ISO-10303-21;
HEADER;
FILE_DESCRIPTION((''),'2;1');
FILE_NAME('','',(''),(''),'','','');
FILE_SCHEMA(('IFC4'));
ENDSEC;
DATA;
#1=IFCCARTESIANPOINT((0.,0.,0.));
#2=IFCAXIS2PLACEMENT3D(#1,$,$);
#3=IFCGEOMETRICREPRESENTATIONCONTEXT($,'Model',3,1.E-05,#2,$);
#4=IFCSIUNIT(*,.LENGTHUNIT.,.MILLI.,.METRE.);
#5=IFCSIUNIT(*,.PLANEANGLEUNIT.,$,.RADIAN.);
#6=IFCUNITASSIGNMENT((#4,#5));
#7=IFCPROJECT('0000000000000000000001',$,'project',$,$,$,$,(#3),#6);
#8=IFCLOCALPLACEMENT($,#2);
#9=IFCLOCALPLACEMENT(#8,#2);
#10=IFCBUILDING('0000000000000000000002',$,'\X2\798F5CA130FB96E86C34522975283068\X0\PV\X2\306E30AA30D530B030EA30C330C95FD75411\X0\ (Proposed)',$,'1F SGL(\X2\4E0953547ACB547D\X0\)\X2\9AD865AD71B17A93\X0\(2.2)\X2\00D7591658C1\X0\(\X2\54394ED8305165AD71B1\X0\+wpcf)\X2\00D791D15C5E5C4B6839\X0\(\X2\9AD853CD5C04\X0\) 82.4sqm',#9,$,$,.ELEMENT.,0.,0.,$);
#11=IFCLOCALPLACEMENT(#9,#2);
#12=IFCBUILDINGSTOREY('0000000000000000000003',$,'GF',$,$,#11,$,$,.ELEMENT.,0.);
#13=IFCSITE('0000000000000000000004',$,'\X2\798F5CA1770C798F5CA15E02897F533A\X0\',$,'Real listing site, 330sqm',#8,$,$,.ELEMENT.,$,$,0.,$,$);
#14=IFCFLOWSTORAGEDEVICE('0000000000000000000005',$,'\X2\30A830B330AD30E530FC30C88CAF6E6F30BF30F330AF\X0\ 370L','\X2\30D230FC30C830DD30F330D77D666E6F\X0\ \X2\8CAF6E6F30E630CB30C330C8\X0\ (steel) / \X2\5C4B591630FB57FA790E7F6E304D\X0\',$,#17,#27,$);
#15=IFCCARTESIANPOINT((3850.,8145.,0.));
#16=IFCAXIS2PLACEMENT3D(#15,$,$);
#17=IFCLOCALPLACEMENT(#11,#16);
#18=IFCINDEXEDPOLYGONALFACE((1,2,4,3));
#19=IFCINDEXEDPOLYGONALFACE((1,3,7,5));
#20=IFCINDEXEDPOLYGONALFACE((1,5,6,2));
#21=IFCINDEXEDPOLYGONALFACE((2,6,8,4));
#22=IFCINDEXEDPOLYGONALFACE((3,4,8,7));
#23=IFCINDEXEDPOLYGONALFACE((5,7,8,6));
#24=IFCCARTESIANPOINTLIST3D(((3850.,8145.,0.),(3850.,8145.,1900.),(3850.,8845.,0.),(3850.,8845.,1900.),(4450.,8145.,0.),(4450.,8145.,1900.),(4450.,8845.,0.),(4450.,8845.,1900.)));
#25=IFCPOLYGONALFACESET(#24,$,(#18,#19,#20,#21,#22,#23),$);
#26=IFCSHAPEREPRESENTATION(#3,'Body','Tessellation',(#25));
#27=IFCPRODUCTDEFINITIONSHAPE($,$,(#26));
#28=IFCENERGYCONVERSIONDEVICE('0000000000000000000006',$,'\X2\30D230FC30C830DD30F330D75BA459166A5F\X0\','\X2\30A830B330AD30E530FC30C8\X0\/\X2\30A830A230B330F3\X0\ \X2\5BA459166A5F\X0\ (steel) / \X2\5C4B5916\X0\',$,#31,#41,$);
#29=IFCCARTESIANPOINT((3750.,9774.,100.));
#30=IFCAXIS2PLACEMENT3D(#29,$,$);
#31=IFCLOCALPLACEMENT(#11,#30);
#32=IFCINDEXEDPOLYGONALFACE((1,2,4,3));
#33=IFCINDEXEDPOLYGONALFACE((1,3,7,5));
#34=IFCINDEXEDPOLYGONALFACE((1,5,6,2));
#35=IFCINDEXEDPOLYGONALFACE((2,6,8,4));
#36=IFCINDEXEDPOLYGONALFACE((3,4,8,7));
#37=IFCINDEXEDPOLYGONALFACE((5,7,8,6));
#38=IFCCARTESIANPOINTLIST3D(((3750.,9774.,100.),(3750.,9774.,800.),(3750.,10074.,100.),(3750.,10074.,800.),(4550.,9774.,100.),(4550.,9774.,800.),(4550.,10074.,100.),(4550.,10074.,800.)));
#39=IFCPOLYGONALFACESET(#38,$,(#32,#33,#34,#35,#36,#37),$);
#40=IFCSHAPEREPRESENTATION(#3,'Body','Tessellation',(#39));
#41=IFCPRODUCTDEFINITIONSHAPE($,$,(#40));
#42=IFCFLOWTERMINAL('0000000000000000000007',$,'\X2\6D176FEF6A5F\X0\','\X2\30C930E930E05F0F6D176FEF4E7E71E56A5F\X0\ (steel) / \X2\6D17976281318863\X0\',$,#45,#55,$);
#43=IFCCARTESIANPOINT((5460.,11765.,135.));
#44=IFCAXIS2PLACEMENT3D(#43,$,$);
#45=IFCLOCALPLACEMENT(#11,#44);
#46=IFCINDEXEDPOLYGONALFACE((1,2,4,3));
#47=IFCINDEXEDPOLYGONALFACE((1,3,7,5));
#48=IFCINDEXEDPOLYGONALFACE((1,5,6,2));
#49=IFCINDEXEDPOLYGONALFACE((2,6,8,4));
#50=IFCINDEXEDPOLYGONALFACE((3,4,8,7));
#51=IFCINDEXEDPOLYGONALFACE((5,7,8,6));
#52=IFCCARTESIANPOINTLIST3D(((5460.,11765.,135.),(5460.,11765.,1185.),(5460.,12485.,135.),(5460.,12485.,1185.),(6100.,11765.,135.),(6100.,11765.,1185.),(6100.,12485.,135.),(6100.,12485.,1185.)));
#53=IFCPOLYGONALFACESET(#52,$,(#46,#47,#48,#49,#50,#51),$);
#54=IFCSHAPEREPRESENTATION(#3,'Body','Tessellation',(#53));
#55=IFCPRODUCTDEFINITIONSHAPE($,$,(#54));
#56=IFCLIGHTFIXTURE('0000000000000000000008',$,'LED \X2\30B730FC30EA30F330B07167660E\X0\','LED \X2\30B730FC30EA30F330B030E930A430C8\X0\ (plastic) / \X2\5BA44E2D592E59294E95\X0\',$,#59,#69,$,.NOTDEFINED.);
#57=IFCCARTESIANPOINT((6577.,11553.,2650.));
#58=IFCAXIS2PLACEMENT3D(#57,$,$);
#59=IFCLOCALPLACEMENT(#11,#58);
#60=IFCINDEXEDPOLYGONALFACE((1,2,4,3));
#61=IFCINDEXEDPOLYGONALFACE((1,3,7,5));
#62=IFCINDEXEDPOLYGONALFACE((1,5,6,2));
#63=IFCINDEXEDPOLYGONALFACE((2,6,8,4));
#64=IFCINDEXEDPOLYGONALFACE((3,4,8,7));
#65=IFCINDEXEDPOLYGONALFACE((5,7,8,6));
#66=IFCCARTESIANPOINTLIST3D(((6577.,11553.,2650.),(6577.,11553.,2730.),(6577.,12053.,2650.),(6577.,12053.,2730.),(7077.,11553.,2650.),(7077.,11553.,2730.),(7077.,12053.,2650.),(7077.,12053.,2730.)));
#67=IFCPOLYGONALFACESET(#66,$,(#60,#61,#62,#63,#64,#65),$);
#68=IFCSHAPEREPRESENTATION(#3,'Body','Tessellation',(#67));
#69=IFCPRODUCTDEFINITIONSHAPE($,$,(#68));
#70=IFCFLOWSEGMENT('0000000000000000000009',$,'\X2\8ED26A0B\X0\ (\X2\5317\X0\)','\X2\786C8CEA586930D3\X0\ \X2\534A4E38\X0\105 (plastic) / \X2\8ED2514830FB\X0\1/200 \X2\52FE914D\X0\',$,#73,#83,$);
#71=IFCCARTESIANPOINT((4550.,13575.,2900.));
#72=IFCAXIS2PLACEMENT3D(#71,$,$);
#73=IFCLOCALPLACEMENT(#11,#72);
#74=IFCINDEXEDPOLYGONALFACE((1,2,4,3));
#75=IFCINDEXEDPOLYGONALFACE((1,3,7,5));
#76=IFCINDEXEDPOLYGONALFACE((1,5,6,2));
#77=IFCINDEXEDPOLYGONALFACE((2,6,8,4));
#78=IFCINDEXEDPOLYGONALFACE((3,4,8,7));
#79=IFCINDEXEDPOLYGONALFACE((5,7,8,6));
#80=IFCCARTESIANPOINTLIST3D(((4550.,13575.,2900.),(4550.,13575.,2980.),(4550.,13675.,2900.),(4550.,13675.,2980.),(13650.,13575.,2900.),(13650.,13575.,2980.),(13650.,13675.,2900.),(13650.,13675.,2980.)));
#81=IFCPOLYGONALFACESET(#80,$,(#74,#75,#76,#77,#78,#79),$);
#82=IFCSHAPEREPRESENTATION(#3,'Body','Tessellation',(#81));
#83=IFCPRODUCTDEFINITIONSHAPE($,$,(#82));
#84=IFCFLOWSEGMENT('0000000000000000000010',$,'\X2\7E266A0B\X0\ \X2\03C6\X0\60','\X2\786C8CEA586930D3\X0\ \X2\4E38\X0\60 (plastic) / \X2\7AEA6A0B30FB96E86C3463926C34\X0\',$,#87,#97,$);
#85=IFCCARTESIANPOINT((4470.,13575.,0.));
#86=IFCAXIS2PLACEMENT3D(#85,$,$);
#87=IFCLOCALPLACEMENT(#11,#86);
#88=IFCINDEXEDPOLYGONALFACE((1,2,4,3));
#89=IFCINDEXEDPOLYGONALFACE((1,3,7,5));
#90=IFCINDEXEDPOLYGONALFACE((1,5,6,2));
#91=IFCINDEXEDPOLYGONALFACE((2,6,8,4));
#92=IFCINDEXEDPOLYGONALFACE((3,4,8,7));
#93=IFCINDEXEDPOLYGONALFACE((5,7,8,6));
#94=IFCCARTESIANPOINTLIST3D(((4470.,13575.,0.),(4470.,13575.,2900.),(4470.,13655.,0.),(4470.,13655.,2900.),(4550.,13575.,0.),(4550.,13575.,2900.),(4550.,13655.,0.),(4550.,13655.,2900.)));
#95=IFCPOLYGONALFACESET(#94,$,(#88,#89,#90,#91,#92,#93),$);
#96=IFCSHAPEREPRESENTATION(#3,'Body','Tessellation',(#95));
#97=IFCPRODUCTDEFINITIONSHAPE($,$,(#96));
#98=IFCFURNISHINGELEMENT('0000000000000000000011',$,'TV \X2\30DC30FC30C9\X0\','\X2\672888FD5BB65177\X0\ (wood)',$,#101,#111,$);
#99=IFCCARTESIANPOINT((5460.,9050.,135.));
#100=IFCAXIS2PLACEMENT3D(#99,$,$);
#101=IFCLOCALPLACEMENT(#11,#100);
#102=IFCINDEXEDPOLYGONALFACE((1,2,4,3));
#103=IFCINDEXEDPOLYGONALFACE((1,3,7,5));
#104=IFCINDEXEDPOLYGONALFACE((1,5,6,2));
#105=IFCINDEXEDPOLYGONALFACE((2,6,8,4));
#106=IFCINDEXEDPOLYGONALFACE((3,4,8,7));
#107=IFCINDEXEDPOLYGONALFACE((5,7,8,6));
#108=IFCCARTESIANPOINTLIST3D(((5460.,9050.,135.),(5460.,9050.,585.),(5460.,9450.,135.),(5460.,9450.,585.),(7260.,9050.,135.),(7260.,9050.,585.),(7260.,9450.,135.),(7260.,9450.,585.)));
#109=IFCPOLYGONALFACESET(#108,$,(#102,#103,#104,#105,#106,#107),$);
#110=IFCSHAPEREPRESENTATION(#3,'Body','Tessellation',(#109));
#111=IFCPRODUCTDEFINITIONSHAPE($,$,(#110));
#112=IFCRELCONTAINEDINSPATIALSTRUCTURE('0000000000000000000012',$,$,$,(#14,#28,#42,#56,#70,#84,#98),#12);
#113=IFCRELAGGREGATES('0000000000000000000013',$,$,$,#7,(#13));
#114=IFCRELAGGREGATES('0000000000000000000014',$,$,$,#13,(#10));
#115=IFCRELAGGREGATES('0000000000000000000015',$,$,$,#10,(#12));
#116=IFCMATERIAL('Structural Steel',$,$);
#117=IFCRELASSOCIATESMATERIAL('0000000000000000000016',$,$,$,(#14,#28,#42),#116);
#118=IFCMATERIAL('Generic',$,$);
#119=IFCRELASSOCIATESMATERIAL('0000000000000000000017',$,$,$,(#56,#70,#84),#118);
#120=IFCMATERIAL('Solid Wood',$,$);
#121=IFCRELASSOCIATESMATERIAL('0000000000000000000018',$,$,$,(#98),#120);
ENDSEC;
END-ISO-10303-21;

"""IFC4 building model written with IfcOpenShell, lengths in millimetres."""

from ifc_helpers import new_model, si_unit, frame, frame_2d, origin, place, context, project, spatial, rectangle, extrude, material, element, save


model = new_model("IFC4")

# Units and contexts
model_context = context("Model", 3, precision=1e-05, world=origin())
ifc_project = project(units=[si_unit("LENGTHUNIT", "METRE", prefix="MILLI"), si_unit("PLANEANGLEUNIT", "RADIAN")], contexts=[model_context])

# Site, building, storey
site_placement = place(None, origin())
site = spatial("IfcSite", under=ifc_project, at=site_placement, Name="福岡県福岡市西区", ObjectType="Real listing site, 330sqm", CompositionType="ELEMENT", RefElevation=0.0)
building_placement = place(site_placement, origin())
building = spatial("IfcBuilding", under=site, at=building_placement, Name="福岡・雨水利用とPVのオフグリッド志向 (Proposed)", ObjectType="1F SGL(三協立命)高断熱窓(2.2)×外壁(吹付け断熱+wpcf)×金属屋根(高反射) 82.4sqm", CompositionType="ELEMENT", ElevationOfRefHeight=0.0, ElevationOfTerrain=0.0)
storey_placement = place(building_placement, origin())
storey = spatial("IfcBuildingStorey", under=building, at=storey_placement, Name="GF", CompositionType="ELEMENT", Elevation=0.0)

# Shared definitions
ifc_material_1 = material(Name="Solid Wood")

# Shared definitions
ifc_material_2 = material(Name="Structural Steel")

# Shared definitions
ifc_material_3 = material(Name="Generic")

# Flow storage device
flow_storage_device_placement = place(storey_placement, frame((3850.0, 8145.0, 0.0)))
element("IfcFlowStorageDevice", 1, at=flow_storage_device_placement, inside=storey, material=ifc_material_2, Name="エコキュート貯湯タンク 370L", Description="ヒートポンプ給湯 貯湯ユニット (steel) / 屋外・基礎置き", context=model_context, shape_type="SweptSolid", body=[
    extrude(rectangle(XDim=600.0, YDim=700.0, at=frame_2d((300.0, 350.0))), frame((3850.0, 8145.0, 0.0)), (0.0, 0.0, 1.0), 1900.0),
])

# Energy conversion device
energy_conversion_device_placement = place(storey_placement, frame((3750.0, 9774.0, 100.0)))
element("IfcEnergyConversionDevice", 2, at=energy_conversion_device_placement, inside=storey, material=ifc_material_2, Name="ヒートポンプ室外機", Description="エコキュート/エアコン 室外機 (steel) / 屋外", context=model_context, shape_type="SweptSolid", body=[
    extrude(rectangle(XDim=800.0, YDim=300.0, at=frame_2d((400.0, 150.0))), frame((3750.0, 9774.0, 100.0)), (0.0, 0.0, 1.0), 700.0),
])

# Flow terminal
flow_terminal_placement = place(storey_placement, frame((5460.0, 11765.0, 135.0)))
element("IfcFlowTerminal", 3, at=flow_terminal_placement, inside=storey, material=ifc_material_2, Name="洗濯機", Description="ドラム式洗濯乾燥機 (steel) / 洗面脱衣", context=model_context, shape_type="SweptSolid", body=[
    extrude(rectangle(XDim=640.0, YDim=720.0, at=frame_2d((320.0, 360.0))), frame((5460.0, 11765.0, 135.0)), (0.0, 0.0, 1.0), 1050.0),
])

# Light fixture
light_fixture_placement = place(storey_placement, frame((6577.0, 11553.0, 2650.0)))
element("IfcLightFixture", 4, at=light_fixture_placement, inside=storey, material=ifc_material_3, Name="LED シーリング照明", Description="LED シーリングライト (plastic) / 室中央天井", PredefinedType="NOTDEFINED", context=model_context, shape_type="SweptSolid", body=[
    extrude(rectangle(XDim=500.0, YDim=500.0, at=frame_2d((250.0, 250.0))), frame((6577.0, 11553.0, 2650.0)), (0.0, 0.0, 1.0), 80.0),
])

# Flow segments
flow_segment_1_placement = place(storey_placement, frame((4550.0, 13575.0, 2900.0)))
element("IfcFlowSegment", 5, at=flow_segment_1_placement, inside=storey, material=ifc_material_3, Name="軒樋 (北)", Description="硬質塩ビ 半丸105 (plastic) / 軒先・1/200 勾配", context=model_context, shape_type="SweptSolid", body=[
    extrude(rectangle(XDim=9100.0, YDim=100.0, at=frame_2d((4550.0, 50.0))), frame((4550.0, 13575.0, 2900.0)), (0.0, 0.0, 1.0), 80.0),
])
flow_segment_2_placement = place(storey_placement, frame((4470.0, 13575.0, 0.0)))
element("IfcFlowSegment", 6, at=flow_segment_2_placement, inside=storey, material=ifc_material_3, Name="縦樋 φ60", Description="硬質塩ビ 丸60 (plastic) / 竪樋・雨水排水", context=model_context, shape_type="SweptSolid", body=[
    extrude(rectangle(XDim=80.0, YDim=80.0, at=frame_2d((40.0, 40.0))), frame((4470.0, 13575.0, 0.0)), (0.0, 0.0, 1.0), 2900.0),
])

# Furnishing element
furnishing_placement = place(storey_placement, frame((5460.0, 9050.0, 135.0)))
element("IfcFurnishingElement", 7, at=furnishing_placement, inside=storey, material=ifc_material_1, Name="TV ボード", Description="木製家具 (wood)", context=model_context, shape_type="SweptSolid", body=[
    extrude(rectangle(XDim=1800.0, YDim=400.0, at=frame_2d((900.0, 200.0))), frame((5460.0, 9050.0, 135.0)), (0.0, 0.0, 1.0), 450.0),
])

save(model, "model.ifc")
